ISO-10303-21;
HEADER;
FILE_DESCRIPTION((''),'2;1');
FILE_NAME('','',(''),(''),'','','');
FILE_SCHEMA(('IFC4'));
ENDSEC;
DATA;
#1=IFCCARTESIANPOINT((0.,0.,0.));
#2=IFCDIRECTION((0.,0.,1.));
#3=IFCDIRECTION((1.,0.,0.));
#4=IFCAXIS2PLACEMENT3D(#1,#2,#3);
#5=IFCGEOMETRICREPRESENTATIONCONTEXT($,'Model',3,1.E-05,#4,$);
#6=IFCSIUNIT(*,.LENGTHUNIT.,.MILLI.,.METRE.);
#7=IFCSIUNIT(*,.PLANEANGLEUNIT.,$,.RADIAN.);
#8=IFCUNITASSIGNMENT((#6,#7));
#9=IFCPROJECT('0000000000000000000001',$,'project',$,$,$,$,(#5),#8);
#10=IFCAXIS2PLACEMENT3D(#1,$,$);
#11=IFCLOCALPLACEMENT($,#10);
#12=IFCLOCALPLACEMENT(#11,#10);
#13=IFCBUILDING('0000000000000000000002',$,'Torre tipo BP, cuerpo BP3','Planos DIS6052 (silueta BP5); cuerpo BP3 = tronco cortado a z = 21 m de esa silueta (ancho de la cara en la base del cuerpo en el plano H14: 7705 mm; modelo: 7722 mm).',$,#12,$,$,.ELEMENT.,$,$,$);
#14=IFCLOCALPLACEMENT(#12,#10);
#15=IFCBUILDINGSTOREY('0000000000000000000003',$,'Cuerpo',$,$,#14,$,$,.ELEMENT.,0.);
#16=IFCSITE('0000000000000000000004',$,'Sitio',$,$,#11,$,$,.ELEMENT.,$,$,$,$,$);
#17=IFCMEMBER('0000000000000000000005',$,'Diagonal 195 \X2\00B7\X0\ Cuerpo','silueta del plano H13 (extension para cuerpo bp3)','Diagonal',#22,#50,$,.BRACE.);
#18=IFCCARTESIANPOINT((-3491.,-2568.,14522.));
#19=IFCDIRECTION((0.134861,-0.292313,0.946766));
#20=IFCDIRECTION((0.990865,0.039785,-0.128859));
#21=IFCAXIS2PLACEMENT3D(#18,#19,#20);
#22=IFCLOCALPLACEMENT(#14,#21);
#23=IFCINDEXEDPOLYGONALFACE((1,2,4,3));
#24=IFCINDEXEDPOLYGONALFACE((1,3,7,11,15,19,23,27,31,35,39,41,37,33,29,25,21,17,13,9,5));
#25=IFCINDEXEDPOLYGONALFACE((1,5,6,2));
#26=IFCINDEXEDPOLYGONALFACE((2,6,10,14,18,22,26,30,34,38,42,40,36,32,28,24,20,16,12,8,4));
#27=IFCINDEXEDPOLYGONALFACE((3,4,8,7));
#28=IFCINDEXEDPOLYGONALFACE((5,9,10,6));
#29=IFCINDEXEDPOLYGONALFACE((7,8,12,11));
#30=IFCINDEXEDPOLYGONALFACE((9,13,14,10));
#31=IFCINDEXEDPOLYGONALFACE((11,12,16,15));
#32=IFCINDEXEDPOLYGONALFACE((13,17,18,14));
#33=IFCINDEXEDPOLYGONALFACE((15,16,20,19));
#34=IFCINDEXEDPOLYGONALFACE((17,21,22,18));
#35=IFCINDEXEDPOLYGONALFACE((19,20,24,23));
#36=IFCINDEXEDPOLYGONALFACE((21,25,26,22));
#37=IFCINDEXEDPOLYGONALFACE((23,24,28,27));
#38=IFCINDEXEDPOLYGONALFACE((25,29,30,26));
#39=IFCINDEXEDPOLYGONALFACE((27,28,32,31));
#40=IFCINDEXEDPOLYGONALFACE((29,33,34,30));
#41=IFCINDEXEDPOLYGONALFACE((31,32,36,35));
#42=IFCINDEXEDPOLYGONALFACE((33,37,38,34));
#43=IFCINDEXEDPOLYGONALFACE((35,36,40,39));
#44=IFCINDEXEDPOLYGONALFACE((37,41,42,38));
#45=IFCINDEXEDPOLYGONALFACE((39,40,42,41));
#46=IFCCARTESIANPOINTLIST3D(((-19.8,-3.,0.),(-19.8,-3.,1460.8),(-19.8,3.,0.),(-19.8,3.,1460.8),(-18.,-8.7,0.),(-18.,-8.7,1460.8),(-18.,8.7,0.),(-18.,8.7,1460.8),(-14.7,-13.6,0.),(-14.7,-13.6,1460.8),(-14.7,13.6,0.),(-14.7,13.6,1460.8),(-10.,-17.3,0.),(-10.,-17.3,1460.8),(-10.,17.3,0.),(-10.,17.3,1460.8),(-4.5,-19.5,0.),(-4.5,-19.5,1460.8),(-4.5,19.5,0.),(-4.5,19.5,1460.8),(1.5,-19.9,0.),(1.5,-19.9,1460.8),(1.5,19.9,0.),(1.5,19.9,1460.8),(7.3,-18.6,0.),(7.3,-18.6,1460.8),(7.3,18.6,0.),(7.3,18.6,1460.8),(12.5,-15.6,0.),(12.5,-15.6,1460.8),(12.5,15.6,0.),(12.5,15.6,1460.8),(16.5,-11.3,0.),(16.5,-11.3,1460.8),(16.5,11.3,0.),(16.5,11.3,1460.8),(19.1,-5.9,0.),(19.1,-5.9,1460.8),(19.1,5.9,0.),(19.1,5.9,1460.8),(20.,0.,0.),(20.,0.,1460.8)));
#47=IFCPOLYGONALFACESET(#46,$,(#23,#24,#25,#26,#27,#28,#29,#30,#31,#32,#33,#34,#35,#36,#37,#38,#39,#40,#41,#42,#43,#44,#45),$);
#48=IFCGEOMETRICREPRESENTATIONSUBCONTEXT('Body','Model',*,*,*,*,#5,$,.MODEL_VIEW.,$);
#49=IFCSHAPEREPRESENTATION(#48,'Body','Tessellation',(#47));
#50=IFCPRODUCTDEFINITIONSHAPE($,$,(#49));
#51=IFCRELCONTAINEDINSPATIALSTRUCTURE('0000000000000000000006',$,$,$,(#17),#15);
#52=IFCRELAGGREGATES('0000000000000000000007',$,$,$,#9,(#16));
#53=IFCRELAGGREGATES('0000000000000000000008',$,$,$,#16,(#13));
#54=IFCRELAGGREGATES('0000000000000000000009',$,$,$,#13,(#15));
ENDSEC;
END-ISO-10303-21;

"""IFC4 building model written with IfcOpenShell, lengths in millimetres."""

from ifc_helpers import new_model, si_unit, frame, origin, origin_with_axes, place, context, subcontext, project, spatial, circle, extrude, element, save


model = new_model("IFC4")

# Units and contexts
model_context = context("Model", 3, precision=1e-05, world=origin_with_axes())
body_context = subcontext(model_context, "Body", "Model", "MODEL_VIEW")
ifc_project = project(units=[si_unit("LENGTHUNIT", "METRE", prefix="MILLI"), si_unit("PLANEANGLEUNIT", "RADIAN")], contexts=[model_context])

# Site, building, storey
site_placement = place(None, origin())
site = spatial("IfcSite", under=ifc_project, at=site_placement, Name="Sitio", CompositionType="ELEMENT")
building_placement = place(site_placement, origin())
building = spatial("IfcBuilding", under=site, at=building_placement, Name="Torre tipo BP, cuerpo BP3", Description="Planos DIS6052 (silueta BP5); cuerpo BP3 = tronco cortado a z = 21 m de esa silueta (ancho de la cara en la base del cuerpo en el plano H14: 7705 mm; modelo: 7722 mm).", CompositionType="ELEMENT")
storey_placement = place(building_placement, origin())
storey = spatial("IfcBuildingStorey", under=building, at=storey_placement, Name="Cuerpo", CompositionType="ELEMENT", Elevation=0.0)

# Member
member_1_placement = place(storey_placement, frame((-3491.0, -2568.0, 14522.0), z_axis=(0.134861, -0.292313, 0.946766), x_axis=(0.990865, 0.039785, -0.128859)))
element("IfcMember", 1, at=member_1_placement, inside=storey, Name="Diagonal 195 · Cuerpo", Description="silueta del plano H13 (extension para cuerpo bp3)", ObjectType="Diagonal", PredefinedType="BRACE", context=body_context, shape_type="SweptSolid", body=[
    extrude(circle(Radius=20.0), None, (0.0, 0.0, 1.0), 1460.8),
])

save(model, "model.ifc")
